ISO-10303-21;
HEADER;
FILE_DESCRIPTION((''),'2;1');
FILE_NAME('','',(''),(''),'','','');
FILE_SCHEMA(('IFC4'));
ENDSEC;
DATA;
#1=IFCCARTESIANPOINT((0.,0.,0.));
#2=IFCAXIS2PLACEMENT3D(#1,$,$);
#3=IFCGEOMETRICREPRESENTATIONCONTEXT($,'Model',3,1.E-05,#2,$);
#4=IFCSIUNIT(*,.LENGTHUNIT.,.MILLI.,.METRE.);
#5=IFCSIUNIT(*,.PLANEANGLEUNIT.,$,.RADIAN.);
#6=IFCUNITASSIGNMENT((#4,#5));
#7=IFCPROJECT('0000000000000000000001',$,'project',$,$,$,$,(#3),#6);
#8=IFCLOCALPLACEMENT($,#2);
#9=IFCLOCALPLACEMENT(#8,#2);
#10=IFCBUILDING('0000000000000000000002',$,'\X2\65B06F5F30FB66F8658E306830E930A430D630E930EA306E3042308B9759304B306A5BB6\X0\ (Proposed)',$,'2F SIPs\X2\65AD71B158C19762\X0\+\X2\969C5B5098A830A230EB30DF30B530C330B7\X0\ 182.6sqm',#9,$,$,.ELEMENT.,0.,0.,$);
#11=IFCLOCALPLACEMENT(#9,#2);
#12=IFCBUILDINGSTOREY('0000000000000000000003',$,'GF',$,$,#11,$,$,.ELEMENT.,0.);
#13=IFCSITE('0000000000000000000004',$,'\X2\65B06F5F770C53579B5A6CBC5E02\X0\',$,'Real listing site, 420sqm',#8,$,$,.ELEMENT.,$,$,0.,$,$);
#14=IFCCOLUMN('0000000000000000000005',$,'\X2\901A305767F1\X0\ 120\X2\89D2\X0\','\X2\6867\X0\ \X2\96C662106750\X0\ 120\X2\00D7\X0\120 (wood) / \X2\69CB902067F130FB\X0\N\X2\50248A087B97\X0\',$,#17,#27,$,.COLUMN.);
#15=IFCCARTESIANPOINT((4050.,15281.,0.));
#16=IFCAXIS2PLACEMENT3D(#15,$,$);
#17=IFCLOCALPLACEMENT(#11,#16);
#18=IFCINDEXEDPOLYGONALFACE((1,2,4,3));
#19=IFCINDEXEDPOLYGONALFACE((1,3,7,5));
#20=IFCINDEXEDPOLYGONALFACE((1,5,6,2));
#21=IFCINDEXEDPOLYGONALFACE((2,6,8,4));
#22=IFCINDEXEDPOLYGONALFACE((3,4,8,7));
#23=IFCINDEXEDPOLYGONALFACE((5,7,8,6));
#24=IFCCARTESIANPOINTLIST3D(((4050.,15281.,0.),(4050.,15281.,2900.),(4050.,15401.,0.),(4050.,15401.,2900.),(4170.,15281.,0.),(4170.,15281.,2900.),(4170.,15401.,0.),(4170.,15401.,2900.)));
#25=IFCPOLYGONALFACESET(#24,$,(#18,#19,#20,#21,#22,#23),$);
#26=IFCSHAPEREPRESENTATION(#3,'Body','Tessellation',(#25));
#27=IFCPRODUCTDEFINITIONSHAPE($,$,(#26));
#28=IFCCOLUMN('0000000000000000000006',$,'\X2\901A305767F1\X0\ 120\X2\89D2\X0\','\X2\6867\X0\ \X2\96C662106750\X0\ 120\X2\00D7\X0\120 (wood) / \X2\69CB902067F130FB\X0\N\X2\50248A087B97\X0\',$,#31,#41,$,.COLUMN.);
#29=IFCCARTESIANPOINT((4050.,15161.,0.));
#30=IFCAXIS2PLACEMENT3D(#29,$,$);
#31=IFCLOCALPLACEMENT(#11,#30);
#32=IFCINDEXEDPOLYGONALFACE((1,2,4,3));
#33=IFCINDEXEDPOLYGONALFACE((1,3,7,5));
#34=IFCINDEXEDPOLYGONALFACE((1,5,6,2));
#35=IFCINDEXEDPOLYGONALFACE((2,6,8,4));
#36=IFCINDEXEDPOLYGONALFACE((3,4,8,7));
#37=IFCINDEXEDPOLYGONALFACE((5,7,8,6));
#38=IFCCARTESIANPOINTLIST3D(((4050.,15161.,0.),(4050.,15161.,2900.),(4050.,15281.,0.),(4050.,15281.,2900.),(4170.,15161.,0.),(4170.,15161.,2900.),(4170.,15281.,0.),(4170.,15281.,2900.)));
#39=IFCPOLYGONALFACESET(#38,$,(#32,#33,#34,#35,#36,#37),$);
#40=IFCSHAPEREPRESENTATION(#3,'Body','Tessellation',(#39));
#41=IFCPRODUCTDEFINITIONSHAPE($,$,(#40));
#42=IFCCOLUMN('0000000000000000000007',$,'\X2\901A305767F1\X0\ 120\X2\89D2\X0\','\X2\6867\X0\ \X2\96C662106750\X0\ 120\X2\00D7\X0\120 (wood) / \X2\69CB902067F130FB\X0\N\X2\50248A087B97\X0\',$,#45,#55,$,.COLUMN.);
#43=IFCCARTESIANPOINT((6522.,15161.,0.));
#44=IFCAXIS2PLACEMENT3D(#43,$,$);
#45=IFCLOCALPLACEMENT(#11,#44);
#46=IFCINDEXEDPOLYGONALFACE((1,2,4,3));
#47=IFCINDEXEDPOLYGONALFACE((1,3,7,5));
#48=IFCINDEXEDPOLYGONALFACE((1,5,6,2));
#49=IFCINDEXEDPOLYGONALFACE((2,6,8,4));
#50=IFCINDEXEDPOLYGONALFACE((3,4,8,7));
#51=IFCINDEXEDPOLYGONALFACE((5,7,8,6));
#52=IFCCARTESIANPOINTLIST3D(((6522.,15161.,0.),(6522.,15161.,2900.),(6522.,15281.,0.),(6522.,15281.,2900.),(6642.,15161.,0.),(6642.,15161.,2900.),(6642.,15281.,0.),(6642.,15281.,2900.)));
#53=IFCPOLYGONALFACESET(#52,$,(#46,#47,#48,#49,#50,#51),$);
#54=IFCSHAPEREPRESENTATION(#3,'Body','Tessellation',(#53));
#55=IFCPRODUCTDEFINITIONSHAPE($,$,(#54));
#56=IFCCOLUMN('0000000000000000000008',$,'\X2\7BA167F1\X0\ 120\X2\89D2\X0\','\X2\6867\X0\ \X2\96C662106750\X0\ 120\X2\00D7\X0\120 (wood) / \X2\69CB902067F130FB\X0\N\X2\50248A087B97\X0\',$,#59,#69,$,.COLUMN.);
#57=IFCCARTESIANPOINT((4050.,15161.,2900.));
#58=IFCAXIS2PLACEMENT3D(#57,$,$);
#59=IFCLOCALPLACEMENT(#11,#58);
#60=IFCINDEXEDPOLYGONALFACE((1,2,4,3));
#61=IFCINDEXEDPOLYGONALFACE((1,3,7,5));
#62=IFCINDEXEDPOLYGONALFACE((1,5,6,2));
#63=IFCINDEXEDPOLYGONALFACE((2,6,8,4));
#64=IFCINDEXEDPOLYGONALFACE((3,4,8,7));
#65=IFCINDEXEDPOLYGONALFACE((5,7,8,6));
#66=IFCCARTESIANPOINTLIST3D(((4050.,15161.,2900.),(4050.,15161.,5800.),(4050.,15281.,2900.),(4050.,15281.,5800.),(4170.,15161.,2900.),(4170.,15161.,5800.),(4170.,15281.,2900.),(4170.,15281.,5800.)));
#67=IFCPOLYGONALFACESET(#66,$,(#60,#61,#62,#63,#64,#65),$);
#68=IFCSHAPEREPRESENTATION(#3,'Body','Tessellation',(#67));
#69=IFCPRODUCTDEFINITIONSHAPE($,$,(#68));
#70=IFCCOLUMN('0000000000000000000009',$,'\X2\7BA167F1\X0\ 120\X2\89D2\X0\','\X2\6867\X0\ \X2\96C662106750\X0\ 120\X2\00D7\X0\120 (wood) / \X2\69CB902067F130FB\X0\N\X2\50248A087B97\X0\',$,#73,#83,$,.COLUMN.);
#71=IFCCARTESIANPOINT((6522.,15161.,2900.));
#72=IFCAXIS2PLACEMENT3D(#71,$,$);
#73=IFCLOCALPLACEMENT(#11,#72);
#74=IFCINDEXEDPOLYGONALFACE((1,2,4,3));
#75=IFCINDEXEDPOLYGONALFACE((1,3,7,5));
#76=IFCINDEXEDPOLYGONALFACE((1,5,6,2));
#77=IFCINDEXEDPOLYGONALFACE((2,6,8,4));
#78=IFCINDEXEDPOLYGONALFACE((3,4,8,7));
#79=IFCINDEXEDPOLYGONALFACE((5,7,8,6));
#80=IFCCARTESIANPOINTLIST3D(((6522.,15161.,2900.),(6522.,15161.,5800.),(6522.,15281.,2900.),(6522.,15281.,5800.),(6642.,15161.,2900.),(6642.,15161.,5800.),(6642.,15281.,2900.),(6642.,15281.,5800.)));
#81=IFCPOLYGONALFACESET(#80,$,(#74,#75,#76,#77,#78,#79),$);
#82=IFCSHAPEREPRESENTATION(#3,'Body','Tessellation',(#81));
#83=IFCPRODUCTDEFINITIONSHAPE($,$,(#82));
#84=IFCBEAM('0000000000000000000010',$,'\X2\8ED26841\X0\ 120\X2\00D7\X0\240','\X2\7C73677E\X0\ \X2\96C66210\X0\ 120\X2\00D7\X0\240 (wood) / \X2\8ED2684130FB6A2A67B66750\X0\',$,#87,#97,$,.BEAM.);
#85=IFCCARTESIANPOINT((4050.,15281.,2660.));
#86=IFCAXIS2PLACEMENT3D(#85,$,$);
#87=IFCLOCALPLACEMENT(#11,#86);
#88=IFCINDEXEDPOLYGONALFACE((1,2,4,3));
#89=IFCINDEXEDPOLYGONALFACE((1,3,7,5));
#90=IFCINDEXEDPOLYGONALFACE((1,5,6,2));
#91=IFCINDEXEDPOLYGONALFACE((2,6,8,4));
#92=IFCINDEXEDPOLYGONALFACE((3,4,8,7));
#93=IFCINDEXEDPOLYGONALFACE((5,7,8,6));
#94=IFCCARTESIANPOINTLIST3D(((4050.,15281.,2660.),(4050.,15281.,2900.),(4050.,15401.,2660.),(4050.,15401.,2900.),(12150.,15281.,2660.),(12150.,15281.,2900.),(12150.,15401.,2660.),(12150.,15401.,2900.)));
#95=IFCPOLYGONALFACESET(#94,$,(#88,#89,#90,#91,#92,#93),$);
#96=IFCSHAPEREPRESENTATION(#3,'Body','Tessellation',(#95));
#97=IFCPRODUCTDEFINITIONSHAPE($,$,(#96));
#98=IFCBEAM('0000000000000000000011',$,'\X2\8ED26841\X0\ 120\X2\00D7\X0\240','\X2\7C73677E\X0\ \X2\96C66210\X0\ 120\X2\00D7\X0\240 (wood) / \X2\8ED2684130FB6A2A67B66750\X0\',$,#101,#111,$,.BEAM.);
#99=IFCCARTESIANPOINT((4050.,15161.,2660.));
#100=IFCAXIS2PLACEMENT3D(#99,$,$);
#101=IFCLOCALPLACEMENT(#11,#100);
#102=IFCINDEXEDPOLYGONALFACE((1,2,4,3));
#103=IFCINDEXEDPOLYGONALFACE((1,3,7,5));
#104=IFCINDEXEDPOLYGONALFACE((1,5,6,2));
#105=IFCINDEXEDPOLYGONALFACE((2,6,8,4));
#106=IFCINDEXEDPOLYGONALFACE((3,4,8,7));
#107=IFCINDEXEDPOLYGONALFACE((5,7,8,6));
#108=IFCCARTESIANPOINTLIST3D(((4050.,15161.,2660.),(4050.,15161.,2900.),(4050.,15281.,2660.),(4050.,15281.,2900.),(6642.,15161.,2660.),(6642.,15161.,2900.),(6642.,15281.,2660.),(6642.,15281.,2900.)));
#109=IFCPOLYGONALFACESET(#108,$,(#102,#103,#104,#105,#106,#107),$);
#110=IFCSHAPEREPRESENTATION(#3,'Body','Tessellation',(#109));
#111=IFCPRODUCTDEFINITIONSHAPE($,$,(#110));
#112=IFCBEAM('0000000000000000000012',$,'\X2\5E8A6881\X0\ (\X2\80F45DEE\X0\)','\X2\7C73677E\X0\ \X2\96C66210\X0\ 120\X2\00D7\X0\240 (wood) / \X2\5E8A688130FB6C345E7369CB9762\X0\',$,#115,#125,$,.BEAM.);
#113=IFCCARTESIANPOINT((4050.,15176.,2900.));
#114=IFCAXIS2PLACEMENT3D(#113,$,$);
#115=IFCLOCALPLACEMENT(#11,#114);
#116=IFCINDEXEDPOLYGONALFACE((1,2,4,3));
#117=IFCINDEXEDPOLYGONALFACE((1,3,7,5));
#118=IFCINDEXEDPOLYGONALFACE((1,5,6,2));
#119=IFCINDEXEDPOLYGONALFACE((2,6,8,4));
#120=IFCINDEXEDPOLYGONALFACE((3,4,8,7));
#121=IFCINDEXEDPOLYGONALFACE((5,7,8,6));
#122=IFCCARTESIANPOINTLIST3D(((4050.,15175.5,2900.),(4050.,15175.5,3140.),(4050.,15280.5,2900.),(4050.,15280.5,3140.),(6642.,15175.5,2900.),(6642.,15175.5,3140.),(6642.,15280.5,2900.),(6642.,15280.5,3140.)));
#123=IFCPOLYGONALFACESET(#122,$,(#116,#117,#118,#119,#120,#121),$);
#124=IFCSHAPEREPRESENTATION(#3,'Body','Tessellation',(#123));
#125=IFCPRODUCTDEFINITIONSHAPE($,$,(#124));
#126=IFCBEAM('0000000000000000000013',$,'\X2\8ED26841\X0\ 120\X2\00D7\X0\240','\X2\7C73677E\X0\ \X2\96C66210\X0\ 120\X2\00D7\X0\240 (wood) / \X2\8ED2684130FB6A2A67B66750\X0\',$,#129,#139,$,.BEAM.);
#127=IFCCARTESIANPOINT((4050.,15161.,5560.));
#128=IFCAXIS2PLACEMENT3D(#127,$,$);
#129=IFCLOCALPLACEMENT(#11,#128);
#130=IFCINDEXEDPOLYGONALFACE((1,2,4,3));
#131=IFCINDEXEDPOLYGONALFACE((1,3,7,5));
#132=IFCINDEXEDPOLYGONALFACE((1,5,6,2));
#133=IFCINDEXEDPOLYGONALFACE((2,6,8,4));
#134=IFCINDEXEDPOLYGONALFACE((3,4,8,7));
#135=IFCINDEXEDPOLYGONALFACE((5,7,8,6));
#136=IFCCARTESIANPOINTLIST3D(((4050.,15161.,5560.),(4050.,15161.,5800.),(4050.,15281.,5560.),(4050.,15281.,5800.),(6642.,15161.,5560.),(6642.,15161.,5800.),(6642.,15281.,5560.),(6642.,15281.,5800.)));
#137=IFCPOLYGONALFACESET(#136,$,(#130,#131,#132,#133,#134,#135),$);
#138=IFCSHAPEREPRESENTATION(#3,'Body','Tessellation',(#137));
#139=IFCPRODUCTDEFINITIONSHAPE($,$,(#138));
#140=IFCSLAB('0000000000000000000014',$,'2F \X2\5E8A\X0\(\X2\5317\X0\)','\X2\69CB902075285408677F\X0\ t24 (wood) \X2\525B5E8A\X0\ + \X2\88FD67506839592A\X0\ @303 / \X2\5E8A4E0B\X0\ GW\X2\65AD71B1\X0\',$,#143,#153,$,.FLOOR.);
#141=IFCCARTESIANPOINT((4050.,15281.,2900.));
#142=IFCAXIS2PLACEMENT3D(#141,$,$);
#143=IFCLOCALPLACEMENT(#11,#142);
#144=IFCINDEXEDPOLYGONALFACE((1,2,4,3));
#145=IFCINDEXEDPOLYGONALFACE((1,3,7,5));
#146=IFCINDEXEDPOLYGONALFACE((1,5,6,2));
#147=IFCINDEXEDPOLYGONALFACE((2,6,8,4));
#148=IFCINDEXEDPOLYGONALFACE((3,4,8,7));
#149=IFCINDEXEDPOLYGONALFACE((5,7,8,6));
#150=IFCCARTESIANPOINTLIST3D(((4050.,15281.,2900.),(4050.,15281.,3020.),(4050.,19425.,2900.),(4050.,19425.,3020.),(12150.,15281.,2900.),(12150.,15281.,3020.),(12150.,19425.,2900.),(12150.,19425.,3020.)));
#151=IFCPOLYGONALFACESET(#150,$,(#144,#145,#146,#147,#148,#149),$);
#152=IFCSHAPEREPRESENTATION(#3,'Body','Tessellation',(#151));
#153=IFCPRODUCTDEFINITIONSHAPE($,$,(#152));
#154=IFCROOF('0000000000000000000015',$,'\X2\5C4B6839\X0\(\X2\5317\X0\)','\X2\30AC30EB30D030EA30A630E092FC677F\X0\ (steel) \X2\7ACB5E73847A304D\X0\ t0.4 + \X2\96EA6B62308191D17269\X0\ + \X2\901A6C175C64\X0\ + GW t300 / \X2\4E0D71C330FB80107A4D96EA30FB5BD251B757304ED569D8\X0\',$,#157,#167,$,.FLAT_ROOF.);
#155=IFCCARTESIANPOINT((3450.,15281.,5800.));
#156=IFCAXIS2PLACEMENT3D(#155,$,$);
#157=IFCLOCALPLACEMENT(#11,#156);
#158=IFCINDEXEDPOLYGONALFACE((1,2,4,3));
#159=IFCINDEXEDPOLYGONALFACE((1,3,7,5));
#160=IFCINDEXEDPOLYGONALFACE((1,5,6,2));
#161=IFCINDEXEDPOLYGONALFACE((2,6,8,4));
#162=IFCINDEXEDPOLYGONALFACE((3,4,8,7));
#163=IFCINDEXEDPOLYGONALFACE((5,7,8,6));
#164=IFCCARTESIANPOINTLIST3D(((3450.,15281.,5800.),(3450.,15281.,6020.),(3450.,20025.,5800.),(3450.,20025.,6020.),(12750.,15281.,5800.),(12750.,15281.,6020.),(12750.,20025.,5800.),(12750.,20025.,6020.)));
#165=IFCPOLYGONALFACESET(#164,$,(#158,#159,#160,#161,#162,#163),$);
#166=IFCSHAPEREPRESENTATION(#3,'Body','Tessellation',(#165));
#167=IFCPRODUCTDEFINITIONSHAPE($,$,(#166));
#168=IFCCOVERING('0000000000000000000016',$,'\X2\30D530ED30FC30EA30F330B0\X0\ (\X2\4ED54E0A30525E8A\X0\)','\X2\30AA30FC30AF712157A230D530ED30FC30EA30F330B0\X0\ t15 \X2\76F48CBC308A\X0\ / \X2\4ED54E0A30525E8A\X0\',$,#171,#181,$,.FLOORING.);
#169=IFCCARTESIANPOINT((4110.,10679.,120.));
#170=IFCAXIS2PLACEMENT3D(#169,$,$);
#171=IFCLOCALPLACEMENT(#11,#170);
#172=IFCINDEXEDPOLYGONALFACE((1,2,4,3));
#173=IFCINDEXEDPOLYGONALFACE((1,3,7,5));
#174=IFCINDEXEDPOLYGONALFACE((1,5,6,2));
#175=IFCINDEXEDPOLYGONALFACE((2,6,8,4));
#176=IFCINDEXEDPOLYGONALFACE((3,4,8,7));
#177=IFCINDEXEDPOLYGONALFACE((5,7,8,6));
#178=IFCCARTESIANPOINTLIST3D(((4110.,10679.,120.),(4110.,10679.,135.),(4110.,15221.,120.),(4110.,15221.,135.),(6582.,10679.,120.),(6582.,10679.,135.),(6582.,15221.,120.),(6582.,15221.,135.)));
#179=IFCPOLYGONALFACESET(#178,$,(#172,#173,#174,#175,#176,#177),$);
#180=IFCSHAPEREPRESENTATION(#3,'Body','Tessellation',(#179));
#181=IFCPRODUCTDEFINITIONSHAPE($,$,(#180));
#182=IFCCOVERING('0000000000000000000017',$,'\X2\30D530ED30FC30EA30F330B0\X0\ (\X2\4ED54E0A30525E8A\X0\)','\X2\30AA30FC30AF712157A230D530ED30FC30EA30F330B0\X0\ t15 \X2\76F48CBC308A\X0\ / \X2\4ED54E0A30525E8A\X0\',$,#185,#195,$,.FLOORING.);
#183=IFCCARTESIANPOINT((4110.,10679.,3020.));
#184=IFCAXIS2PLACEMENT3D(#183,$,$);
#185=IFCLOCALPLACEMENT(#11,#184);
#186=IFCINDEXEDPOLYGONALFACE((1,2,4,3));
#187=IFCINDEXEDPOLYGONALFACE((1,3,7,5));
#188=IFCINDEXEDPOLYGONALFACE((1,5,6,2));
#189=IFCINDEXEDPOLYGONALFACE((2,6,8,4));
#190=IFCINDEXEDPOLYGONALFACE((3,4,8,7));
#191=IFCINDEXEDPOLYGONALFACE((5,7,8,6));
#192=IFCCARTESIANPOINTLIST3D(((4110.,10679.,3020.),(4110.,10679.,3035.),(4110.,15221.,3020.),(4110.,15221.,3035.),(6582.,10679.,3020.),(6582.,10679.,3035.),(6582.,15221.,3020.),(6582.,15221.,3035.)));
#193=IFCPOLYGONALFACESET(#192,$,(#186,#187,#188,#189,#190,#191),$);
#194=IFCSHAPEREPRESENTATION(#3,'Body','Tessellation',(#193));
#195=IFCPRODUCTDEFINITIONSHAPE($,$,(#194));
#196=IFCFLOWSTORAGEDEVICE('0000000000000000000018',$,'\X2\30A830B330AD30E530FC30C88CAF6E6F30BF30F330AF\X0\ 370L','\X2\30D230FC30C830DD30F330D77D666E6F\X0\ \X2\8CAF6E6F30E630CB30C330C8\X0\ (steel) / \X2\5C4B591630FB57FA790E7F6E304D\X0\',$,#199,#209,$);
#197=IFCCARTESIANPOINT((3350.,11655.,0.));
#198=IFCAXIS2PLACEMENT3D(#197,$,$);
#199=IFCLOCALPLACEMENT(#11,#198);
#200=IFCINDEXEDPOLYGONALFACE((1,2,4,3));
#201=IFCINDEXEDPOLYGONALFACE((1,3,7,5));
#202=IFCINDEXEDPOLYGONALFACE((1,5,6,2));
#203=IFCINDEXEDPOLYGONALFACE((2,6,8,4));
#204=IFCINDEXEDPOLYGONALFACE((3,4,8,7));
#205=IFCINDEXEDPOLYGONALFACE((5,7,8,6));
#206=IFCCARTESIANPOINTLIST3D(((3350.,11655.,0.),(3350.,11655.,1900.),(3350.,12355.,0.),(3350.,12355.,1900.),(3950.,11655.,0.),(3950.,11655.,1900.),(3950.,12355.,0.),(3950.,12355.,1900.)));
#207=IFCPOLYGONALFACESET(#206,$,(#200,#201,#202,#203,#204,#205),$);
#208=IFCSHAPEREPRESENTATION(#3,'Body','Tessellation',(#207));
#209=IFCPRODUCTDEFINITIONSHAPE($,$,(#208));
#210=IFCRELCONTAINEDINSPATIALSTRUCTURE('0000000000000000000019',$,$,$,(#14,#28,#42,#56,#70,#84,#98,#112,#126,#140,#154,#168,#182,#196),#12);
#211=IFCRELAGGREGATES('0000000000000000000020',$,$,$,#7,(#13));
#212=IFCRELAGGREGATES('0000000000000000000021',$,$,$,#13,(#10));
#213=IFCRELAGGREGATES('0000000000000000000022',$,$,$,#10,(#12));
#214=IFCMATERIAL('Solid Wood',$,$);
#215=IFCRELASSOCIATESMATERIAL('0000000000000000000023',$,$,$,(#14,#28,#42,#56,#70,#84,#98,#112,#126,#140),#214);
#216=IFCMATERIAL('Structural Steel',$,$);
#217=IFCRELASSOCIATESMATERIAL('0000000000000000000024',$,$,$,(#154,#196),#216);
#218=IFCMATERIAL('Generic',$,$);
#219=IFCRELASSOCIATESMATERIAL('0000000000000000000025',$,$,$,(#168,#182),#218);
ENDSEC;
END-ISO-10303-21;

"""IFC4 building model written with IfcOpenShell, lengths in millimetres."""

from ifc_helpers import new_model, si_unit, frame, frame_2d, origin, place, context, project, spatial, rectangle, extrude, material, element, save


model = new_model("IFC4")

# Units and contexts
model_context = context("Model", 3, precision=1e-05, world=origin())
ifc_project = project(units=[si_unit("LENGTHUNIT", "METRE", prefix="MILLI"), si_unit("PLANEANGLEUNIT", "RADIAN")], contexts=[model_context])

# Site, building, storey
site_placement = place(None, origin())
site = spatial("IfcSite", under=ifc_project, at=site_placement, Name="新潟県南魚沼市", ObjectType="Real listing site, 420sqm", CompositionType="ELEMENT", RefElevation=0.0)
building_placement = place(site_placement, origin())
building = spatial("IfcBuilding", under=site, at=building_placement, Name="新潟・書斎とライブラリのある静かな家 (Proposed)", ObjectType="2F SIPs断熱壁面+障子風アルミサッシ 182.6sqm", CompositionType="ELEMENT", ElevationOfRefHeight=0.0, ElevationOfTerrain=0.0)
storey_placement = place(building_placement, origin())
storey = spatial("IfcBuildingStorey", under=building, at=storey_placement, Name="GF", CompositionType="ELEMENT", Elevation=0.0)

# Columns
ifc_material_1 = material(Name="Solid Wood")
column_1_placement = place(storey_placement, frame((4050.0, 15281.0, 0.0)))
element("IfcColumn", 1, at=column_1_placement, inside=storey, material=ifc_material_1, Name="通し柱 120角", Description="桧 集成材 120×120 (wood) / 構造柱・N値計算", PredefinedType="COLUMN", context=model_context, shape_type="SweptSolid", body=[
    extrude(rectangle(XDim=120.0, YDim=120.0, at=frame_2d((60.0, 60.0))), frame((4050.0, 15281.0, 0.0)), (0.0, 0.0, 1.0), 2900.0),
])
column_2_placement = place(storey_placement, frame((4050.0, 15161.0, 0.0)))
element("IfcColumn", 2, at=column_2_placement, inside=storey, material=ifc_material_1, Name="通し柱 120角", Description="桧 集成材 120×120 (wood) / 構造柱・N値計算", PredefinedType="COLUMN", context=model_context, shape_type="SweptSolid", body=[
    extrude(rectangle(XDim=120.0, YDim=120.0, at=frame_2d((60.0, 60.0))), frame((4050.0, 15161.0, 0.0)), (0.0, 0.0, 1.0), 2900.0),
])
column_3_placement = place(storey_placement, frame((6522.0, 15161.0, 0.0)))
element("IfcColumn", 3, at=column_3_placement, inside=storey, material=ifc_material_1, Name="通し柱 120角", Description="桧 集成材 120×120 (wood) / 構造柱・N値計算", PredefinedType="COLUMN", context=model_context, shape_type="SweptSolid", body=[
    extrude(rectangle(XDim=120.0, YDim=120.0, at=frame_2d((60.0, 60.0))), frame((6522.0, 15161.0, 0.0)), (0.0, 0.0, 1.0), 2900.0),
])
column_4_placement = place(storey_placement, frame((4050.0, 15161.0, 2900.0)))
element("IfcColumn", 4, at=column_4_placement, inside=storey, material=ifc_material_1, Name="管柱 120角", Description="桧 集成材 120×120 (wood) / 構造柱・N値計算", PredefinedType="COLUMN", context=model_context, shape_type="SweptSolid", body=[
    extrude(rectangle(XDim=120.0, YDim=120.0, at=frame_2d((60.0, 60.0))), frame((4050.0, 15161.0, 2900.0)), (0.0, 0.0, 1.0), 2900.0),
])
column_5_placement = place(storey_placement, frame((6522.0, 15161.0, 2900.0)))
element("IfcColumn", 5, at=column_5_placement, inside=storey, material=ifc_material_1, Name="管柱 120角", Description="桧 集成材 120×120 (wood) / 構造柱・N値計算", PredefinedType="COLUMN", context=model_context, shape_type="SweptSolid", body=[
    extrude(rectangle(XDim=120.0, YDim=120.0, at=frame_2d((60.0, 60.0))), frame((6522.0, 15161.0, 2900.0)), (0.0, 0.0, 1.0), 2900.0),
])

# Beams
beam_1_placement = place(storey_placement, frame((4050.0, 15281.0, 2660.0)))
element("IfcBeam", 6, at=beam_1_placement, inside=storey, material=ifc_material_1, Name="軒桁 120×240", Description="米松 集成 120×240 (wood) / 軒桁・横架材", PredefinedType="BEAM", context=model_context, shape_type="SweptSolid", body=[
    extrude(rectangle(XDim=8100.0, YDim=120.0, at=frame_2d((4050.0, 60.0))), frame((4050.0, 15281.0, 2660.0)), (0.0, 0.0, 1.0), 240.0),
])
beam_2_placement = place(storey_placement, frame((4050.0, 15161.0, 2660.0)))
element("IfcBeam", 7, at=beam_2_placement, inside=storey, material=ifc_material_1, Name="軒桁 120×240", Description="米松 集成 120×240 (wood) / 軒桁・横架材", PredefinedType="BEAM", context=model_context, shape_type="SweptSolid", body=[
    extrude(rectangle(XDim=2592.0, YDim=120.0, at=frame_2d((1296.0, 60.0))), frame((4050.0, 15161.0, 2660.0)), (0.0, 0.0, 1.0), 240.0),
])
beam_3_placement = place(storey_placement, frame((4050.0, 15176.0, 2900.0)))
element("IfcBeam", 8, at=beam_3_placement, inside=storey, material=ifc_material_1, Name="床梁 (胴差)", Description="米松 集成 120×240 (wood) / 床梁・水平構面", PredefinedType="BEAM", context=model_context, shape_type="SweptSolid", body=[
    extrude(rectangle(XDim=2592.0, YDim=105.0, at=frame_2d((1296.0, 52.0))), frame((4050.0, 15176.0, 2900.0)), (0.0, 0.0, 1.0), 240.0),
])
beam_4_placement = place(storey_placement, frame((4050.0, 15161.0, 5560.0)))
element("IfcBeam", 9, at=beam_4_placement, inside=storey, material=ifc_material_1, Name="軒桁 120×240", Description="米松 集成 120×240 (wood) / 軒桁・横架材", PredefinedType="BEAM", context=model_context, shape_type="SweptSolid", body=[
    extrude(rectangle(XDim=2592.0, YDim=120.0, at=frame_2d((1296.0, 60.0))), frame((4050.0, 15161.0, 5560.0)), (0.0, 0.0, 1.0), 240.0),
])

# Slab
slab_1_placement = place(storey_placement, frame((4050.0, 15281.0, 2900.0)))
element("IfcSlab", 10, at=slab_1_placement, inside=storey, material=ifc_material_1, Name="2F 床(北)", Description="構造用合板 t24 (wood) 剛床 + 製材根太 @303 / 床下 GW断熱", PredefinedType="FLOOR", context=model_context, shape_type="SweptSolid", body=[
    extrude(rectangle(XDim=8100.0, YDim=4144.0, at=frame_2d((4050.0, 2072.0))), frame((4050.0, 15281.0, 2900.0)), (0.0, 0.0, 1.0), 120.0),
])

# Roof
ifc_material_2 = material(Name="Structural Steel")
for number, where, name in (
    (11, (3450.0, 15281.0, 5800.0), "屋根(北)"),
):
    element("IfcRoof", number, at=place(storey_placement, frame(where)), inside=storey, material=ifc_material_2, Name=name, Description="ガルバリウム鋼板 (steel) 立平葺き t0.4 + 雪止め金物 + 通気層 + GW t300 / 不燃・耐積雪・寒冷地仕様", PredefinedType="FLAT_ROOF", context=model_context, shape_type="SweptSolid", body=[
        extrude(rectangle(XDim=9300.0, YDim=4744.0, at=frame_2d((4650.0, 2372.0))), frame((3450.0, 15281.0, 5800.0)), (0.0, 0.0, 1.0), 220.0),
    ])

# Coverings
ifc_material_3 = material(Name="Generic")
covering_1_placement = place(storey_placement, frame((4110.0, 10679.0, 120.0)))
element("IfcCovering", 12, at=covering_1_placement, inside=storey, material=ifc_material_3, Name="フローリング (仕上げ床)", Description="オーク無垢フローリング t15 直貼り / 仕上げ床", PredefinedType="FLOORING", context=model_context, shape_type="SweptSolid", body=[
    extrude(rectangle(XDim=2472.0, YDim=4542.0, at=frame_2d((1236.0, 2271.0))), frame((4110.0, 10679.0, 120.0)), (0.0, 0.0, 1.0), 15.0),
])
covering_2_placement = place(storey_placement, frame((4110.0, 10679.0, 3020.0)))
element("IfcCovering", 13, at=covering_2_placement, inside=storey, material=ifc_material_3, Name="フローリング (仕上げ床)", Description="オーク無垢フローリング t15 直貼り / 仕上げ床", PredefinedType="FLOORING", context=model_context, shape_type="SweptSolid", body=[
    extrude(rectangle(XDim=2472.0, YDim=4542.0, at=frame_2d((1236.0, 2271.0))), frame((4110.0, 10679.0, 3020.0)), (0.0, 0.0, 1.0), 15.0),
])

# Flow storage device
flow_storage_device_placement = place(storey_placement, frame((3350.0, 11655.0, 0.0)))
element("IfcFlowStorageDevice", 14, at=flow_storage_device_placement, inside=storey, material=ifc_material_2, Name="エコキュート貯湯タンク 370L", Description="ヒートポンプ給湯 貯湯ユニット (steel) / 屋外・基礎置き", context=model_context, shape_type="SweptSolid", body=[
    extrude(rectangle(XDim=600.0, YDim=700.0, at=frame_2d((300.0, 350.0))), frame((3350.0, 11655.0, 0.0)), (0.0, 0.0, 1.0), 1900.0),
])

save(model, "model.ifc")
